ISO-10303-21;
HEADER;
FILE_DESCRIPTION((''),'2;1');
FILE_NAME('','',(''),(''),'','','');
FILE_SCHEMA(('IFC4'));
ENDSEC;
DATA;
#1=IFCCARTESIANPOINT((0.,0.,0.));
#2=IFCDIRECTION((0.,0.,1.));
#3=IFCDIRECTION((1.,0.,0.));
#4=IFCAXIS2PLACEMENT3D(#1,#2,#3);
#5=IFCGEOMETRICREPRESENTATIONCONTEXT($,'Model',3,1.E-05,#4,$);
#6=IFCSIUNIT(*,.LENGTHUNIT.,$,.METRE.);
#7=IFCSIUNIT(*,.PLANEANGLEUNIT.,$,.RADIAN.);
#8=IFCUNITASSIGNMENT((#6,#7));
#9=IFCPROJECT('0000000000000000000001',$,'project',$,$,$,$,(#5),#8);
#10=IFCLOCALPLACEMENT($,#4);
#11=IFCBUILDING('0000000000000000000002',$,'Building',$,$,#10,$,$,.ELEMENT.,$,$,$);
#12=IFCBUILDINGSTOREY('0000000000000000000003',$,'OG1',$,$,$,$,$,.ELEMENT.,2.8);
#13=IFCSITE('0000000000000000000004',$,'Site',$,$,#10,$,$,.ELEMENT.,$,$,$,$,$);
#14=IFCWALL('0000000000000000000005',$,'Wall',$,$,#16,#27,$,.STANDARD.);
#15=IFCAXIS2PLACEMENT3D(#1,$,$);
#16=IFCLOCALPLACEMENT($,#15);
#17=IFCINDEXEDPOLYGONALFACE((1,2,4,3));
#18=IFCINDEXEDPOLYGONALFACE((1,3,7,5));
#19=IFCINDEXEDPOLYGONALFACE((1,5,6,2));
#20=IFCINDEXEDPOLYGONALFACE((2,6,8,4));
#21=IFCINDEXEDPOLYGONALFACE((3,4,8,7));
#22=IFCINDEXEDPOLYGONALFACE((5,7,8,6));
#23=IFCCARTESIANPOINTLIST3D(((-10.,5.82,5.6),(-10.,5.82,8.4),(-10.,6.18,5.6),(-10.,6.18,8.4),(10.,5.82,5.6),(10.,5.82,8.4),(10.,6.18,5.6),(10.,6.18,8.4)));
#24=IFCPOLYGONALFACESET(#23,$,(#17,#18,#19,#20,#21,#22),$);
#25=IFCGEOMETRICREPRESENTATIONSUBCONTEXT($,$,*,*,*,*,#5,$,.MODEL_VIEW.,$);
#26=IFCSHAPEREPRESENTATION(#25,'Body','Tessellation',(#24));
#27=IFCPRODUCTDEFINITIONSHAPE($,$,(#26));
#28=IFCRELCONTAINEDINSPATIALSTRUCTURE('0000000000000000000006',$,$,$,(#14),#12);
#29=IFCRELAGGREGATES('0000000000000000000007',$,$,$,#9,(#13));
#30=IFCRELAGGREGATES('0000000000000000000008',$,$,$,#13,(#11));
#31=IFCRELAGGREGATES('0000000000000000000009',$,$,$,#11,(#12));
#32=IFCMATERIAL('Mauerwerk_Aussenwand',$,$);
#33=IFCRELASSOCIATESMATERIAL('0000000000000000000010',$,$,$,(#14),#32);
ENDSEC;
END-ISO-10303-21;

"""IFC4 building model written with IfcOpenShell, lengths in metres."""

from ifc_helpers import new_model, si_unit, frame, frame_2d, origin, origin_with_axes, place, context, subcontext, project, spatial, rectangle, extrude, material, element, save


model = new_model("IFC4")

# Units and contexts
model_context = context("Model", 3, precision=1e-05, world=origin_with_axes())
sub_context = subcontext(model_context, None, None, "MODEL_VIEW")
ifc_project = project(units=[si_unit("LENGTHUNIT", "METRE"), si_unit("PLANEANGLEUNIT", "RADIAN")], contexts=[model_context])

# Site, building, storey
placement_1 = place(None, origin_with_axes())
site = spatial("IfcSite", under=ifc_project, at=placement_1, Name="Site", CompositionType="ELEMENT")
building = spatial("IfcBuilding", under=site, at=placement_1, Name="Building", CompositionType="ELEMENT")
storey = spatial("IfcBuildingStorey", under=building, Name="OG1", CompositionType="ELEMENT", Elevation=2.8)

# Wall
ifc_material = material(Name="Mauerwerk_Aussenwand")
placement_2 = place(None, origin_with_axes())
placement_3 = place(placement_2, frame((0.0, 0.0, 2.8)))
wall_placement = place(placement_3, frame((-10.0, 6.0, 2.8), x_axis=(1.0, 0.0, 0.0)))
element("IfcWall", 1, at=wall_placement, inside=storey, material=ifc_material, Name="Wall", PredefinedType="STANDARD", context=sub_context, shape_type="SweptSolid", body=[
    extrude(rectangle(XDim=20.0, YDim=0.36, at=frame_2d((10.0, 0.0))), origin(), (0.0, 0.0, 1.0), 2.8),
])

save(model, "model.ifc")
